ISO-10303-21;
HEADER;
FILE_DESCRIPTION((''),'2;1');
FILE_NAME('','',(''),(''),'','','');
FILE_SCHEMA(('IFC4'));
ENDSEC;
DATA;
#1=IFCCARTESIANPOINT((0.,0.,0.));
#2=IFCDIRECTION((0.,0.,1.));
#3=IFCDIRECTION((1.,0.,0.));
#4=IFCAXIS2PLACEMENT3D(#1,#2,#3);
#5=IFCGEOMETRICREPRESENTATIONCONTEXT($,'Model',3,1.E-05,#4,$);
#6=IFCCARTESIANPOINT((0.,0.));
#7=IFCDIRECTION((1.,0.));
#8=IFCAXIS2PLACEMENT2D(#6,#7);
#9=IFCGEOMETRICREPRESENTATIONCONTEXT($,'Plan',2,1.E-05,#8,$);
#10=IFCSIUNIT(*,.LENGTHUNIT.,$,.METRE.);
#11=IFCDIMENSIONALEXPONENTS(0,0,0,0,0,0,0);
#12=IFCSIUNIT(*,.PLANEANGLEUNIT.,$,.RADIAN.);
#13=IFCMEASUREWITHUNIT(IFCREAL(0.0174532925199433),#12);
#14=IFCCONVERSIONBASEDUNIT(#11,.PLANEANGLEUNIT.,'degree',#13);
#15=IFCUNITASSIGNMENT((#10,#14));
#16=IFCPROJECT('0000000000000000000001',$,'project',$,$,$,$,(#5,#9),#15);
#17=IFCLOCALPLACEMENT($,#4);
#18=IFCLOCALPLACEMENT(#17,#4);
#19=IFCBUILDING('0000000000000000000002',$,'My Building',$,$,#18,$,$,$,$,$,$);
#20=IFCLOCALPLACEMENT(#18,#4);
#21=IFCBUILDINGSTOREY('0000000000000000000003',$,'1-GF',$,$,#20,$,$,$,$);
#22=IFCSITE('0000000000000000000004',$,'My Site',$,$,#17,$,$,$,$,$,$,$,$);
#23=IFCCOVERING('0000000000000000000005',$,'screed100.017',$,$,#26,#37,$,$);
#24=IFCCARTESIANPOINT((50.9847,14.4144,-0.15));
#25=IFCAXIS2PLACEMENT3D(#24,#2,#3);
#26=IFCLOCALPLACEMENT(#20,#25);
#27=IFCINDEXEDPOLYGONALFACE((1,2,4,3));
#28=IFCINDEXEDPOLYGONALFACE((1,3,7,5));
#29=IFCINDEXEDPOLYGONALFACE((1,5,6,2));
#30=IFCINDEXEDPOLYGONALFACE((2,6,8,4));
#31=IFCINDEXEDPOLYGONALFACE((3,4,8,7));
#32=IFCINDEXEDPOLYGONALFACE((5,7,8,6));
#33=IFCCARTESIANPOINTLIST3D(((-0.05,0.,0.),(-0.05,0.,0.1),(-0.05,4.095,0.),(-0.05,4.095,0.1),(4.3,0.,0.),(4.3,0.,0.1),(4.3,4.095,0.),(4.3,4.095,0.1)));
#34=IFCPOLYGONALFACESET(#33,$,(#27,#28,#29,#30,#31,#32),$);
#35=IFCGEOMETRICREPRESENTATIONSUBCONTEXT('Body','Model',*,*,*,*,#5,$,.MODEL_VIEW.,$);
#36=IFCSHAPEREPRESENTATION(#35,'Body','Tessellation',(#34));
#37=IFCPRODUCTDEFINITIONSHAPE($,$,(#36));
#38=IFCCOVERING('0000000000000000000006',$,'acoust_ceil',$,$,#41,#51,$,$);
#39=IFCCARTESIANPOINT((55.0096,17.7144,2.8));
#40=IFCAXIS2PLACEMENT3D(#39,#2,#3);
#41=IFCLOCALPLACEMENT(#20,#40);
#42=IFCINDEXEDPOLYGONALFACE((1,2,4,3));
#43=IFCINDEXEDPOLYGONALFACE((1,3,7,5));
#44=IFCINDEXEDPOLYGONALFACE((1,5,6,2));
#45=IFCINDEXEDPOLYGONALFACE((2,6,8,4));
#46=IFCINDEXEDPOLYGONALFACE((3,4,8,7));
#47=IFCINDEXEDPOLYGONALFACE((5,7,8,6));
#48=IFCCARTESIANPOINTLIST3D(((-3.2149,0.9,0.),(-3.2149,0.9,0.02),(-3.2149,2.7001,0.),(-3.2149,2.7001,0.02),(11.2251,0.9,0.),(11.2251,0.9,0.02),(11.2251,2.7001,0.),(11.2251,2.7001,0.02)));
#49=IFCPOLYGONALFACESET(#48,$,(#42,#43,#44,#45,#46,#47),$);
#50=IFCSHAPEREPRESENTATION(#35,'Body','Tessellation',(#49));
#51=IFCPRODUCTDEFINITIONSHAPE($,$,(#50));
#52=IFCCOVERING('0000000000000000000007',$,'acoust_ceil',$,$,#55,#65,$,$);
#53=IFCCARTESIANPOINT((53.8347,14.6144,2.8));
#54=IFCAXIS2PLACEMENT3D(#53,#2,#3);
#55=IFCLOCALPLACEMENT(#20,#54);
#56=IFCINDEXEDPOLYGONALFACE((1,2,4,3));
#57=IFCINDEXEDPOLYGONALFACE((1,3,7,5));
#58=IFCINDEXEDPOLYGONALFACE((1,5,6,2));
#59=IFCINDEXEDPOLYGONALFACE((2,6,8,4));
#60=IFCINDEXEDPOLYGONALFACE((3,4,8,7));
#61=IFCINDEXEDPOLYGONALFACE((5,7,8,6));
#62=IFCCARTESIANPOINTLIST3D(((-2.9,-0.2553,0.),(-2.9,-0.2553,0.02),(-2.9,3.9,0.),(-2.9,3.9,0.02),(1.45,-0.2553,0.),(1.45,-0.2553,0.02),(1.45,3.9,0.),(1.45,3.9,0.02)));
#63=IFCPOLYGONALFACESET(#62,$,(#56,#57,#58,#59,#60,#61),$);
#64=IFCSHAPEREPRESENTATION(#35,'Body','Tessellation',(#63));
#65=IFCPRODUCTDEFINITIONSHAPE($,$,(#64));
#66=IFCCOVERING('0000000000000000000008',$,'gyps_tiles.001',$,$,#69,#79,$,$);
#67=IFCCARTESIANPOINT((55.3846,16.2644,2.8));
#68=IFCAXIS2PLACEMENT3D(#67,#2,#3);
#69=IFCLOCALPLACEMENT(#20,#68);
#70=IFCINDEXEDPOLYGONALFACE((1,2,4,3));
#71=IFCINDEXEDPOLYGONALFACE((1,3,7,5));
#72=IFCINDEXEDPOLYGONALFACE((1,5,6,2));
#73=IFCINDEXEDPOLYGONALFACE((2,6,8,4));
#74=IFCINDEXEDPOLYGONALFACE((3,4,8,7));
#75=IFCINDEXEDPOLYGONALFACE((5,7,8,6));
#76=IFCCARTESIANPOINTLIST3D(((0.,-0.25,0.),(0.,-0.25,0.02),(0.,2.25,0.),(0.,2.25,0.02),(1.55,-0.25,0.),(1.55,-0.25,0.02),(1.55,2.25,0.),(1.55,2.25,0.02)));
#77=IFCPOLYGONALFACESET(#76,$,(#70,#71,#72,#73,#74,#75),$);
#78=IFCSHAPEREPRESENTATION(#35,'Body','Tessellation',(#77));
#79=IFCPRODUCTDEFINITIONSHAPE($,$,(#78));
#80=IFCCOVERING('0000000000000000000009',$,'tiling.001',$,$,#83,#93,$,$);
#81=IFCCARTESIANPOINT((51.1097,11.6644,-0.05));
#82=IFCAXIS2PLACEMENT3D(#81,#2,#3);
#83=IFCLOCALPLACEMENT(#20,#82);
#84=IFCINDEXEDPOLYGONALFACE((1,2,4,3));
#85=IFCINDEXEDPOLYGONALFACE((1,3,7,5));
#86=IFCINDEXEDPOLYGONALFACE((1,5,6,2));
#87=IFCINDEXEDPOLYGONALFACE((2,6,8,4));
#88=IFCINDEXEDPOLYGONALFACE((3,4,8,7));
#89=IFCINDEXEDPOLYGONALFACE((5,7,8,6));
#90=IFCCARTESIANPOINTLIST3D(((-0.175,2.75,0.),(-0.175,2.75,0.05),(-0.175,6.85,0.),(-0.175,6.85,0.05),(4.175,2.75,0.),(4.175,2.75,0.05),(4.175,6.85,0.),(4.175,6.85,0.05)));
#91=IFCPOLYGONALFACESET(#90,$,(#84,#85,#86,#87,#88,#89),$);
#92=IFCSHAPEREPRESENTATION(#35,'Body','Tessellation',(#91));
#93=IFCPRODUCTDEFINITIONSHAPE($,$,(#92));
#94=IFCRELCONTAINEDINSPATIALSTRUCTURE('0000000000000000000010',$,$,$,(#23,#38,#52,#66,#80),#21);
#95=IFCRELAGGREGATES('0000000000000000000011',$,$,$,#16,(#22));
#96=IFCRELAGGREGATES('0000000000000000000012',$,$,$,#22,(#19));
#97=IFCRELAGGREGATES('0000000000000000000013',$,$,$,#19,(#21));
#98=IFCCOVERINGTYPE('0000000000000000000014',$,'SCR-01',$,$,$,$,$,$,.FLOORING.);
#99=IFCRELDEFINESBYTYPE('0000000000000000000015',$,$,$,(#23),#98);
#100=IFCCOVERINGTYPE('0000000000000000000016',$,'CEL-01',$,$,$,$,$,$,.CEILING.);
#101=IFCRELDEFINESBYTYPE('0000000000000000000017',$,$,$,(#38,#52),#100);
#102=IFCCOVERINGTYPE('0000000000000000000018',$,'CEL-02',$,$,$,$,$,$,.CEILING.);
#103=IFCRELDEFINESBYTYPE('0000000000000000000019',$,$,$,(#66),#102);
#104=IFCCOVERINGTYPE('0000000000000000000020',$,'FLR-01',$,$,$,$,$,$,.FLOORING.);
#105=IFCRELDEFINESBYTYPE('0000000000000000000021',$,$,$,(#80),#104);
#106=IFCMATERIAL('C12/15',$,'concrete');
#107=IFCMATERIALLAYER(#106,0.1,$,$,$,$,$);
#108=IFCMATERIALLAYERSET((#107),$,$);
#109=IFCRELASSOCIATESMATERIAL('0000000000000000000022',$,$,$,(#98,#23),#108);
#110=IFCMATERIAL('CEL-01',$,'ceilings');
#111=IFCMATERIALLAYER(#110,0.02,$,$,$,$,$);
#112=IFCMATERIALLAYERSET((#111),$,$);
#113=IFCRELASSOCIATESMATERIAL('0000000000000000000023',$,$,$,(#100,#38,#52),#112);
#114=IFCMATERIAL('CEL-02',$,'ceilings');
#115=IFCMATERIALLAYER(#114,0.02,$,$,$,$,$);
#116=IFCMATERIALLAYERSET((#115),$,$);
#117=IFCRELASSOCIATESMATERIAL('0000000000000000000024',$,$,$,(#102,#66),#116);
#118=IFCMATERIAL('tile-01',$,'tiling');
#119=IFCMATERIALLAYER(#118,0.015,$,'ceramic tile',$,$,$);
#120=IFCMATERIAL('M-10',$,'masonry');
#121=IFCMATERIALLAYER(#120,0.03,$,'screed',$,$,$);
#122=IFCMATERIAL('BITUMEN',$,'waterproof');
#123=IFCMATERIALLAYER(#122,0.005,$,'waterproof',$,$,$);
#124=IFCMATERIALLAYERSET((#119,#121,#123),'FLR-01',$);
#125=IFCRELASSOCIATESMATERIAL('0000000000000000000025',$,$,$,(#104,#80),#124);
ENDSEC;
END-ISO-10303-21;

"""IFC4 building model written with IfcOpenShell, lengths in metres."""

from ifc_helpers import new_model, entity, si_unit, converted_unit, frame, origin_with_axes, origin_2d_with_axis, place, context, subcontext, project, spatial, line, indexed_curve, outline, extrude, material, layer, layer_set, layer_usage, type_object, element, save


model = new_model("IFC4")

# Units and contexts
model_context = context("Model", 3, precision=1e-05, world=origin_with_axes())
plan_context = context("Plan", 2, precision=1e-05, world=origin_2d_with_axis())
body_context_1 = subcontext(model_context, "Body", "Model", "MODEL_VIEW")
ifc_project = project(units=[si_unit("LENGTHUNIT", "METRE"), converted_unit("PLANEANGLEUNIT", "degree", entity("IfcReal", 0.0174532925199433), si_unit("PLANEANGLEUNIT", "RADIAN"), dimensions=[0, 0, 0, 0, 0, 0, 0])], contexts=[model_context, plan_context])

# Site, building, storey
site_placement = place(None, origin_with_axes())
site = spatial("IfcSite", under=ifc_project, at=site_placement, Name="My Site")
building_placement = place(site_placement, origin_with_axes())
building = spatial("IfcBuilding", under=site, at=building_placement, Name="My Building")
storey_placement = place(building_placement, origin_with_axes())
storey = spatial("IfcBuildingStorey", under=building, at=storey_placement, Name="1-GF")

# Coverings
ifc_material_1 = material(Name="C12/15", Category="concrete")
ifc_layer_1 = layer(ifc_material_1, 0.1)
ifc_layer_set_1 = layer_set([ifc_layer_1])
ifc_layer_usage_1 = layer_usage(ifc_layer_set_1, "AXIS3", "POSITIVE", 0.0)
covering_type_1 = type_object("IfcCoveringType", Name="SCR-01", PredefinedType="FLOORING", material=ifc_layer_set_1)
covering_1_placement = place(storey_placement, frame((50.9847, 14.4144, -0.15), z_axis=(0.0, 0.0, 1.0), x_axis=(1.0, 0.0, 0.0)))
element("IfcCovering", 1, at=covering_1_placement, inside=storey, type_object=covering_type_1, material=ifc_layer_usage_1, Name="screed100.017", context=body_context_1, shape_type="SweptSolid", body=[
    extrude(outline(indexed_curve([(-0.05, 0.0), (4.3, 0.0), (4.3, 4.095), (-0.05, 4.095)], segments=[line(3, 2), line(2, 1), line(1, 4), line(4, 3)], self_intersect=False)), None, (0.0, 0.0, 1.0), 0.1),
])
ifc_material_2 = material(Name="CEL-01", Category="ceilings")
ifc_layer_2 = layer(ifc_material_2, 0.02)
ifc_layer_set_2 = layer_set([ifc_layer_2])
ifc_layer_usage_2 = layer_usage(ifc_layer_set_2, "AXIS3", "POSITIVE", 0.0)
covering_type_2 = type_object("IfcCoveringType", Name="CEL-01", PredefinedType="CEILING", material=ifc_layer_set_2)
covering_2_placement = place(storey_placement, frame((55.0096, 17.7144, 2.8), z_axis=(0.0, 0.0, 1.0), x_axis=(1.0, 0.0, 0.0)))
element("IfcCovering", 2, at=covering_2_placement, inside=storey, type_object=covering_type_2, material=ifc_layer_usage_2, Name="acoust_ceil", context=body_context_1, shape_type="SweptSolid", body=[
    extrude(outline(indexed_curve([(-3.2149, 0.9), (11.2251, 0.9), (11.2251, 2.7001), (-3.2149, 2.7001)], segments=[line(3, 2), line(2, 1), line(1, 4), line(4, 3)], self_intersect=False)), None, (0.0, 0.0, 1.0), 0.02),
])
ifc_layer_usage_3 = layer_usage(ifc_layer_set_2, "AXIS3", "POSITIVE", 0.0)
covering_3_placement = place(storey_placement, frame((53.8347, 14.6144, 2.8), z_axis=(0.0, 0.0, 1.0), x_axis=(1.0, 0.0, 0.0)))
element("IfcCovering", 3, at=covering_3_placement, inside=storey, type_object=covering_type_2, material=ifc_layer_usage_3, Name="acoust_ceil", context=body_context_1, shape_type="SweptSolid", body=[
    extrude(outline(indexed_curve([(-2.9, -0.2553), (1.45, -0.2553), (1.45, 3.9), (-2.9, 3.9)], segments=[line(4, 1), line(1, 2), line(2, 3), line(3, 4)], self_intersect=False)), None, (0.0, 0.0, 1.0), 0.02),
])
ifc_material_3 = material(Name="CEL-02", Category="ceilings")
ifc_layer_3 = layer(ifc_material_3, 0.02)
ifc_layer_set_3 = layer_set([ifc_layer_3])
ifc_layer_usage_4 = layer_usage(ifc_layer_set_3, "AXIS3", "POSITIVE", 0.0)
covering_type_3 = type_object("IfcCoveringType", Name="CEL-02", PredefinedType="CEILING", material=ifc_layer_set_3)
covering_4_placement = place(storey_placement, frame((55.3846, 16.2644, 2.8), z_axis=(0.0, 0.0, 1.0), x_axis=(1.0, 0.0, 0.0)))
element("IfcCovering", 4, at=covering_4_placement, inside=storey, type_object=covering_type_3, material=ifc_layer_usage_4, Name="gyps_tiles.001", context=body_context_1, shape_type="SweptSolid", body=[
    extrude(outline(indexed_curve([(1.55, 2.25), (1.55, -0.25), (0.0, -0.25), (0.0, 2.25)], segments=[line(3, 2), line(2, 1), line(1, 4), line(4, 3)], self_intersect=False)), None, (0.0, 0.0, 1.0), 0.02),
])
ifc_material_4 = material(Name="tile-01", Category="tiling")
ifc_layer_4 = layer(ifc_material_4, 0.015, Name="ceramic tile")
ifc_material_5 = material(Name="M-10", Category="masonry")
ifc_layer_5 = layer(ifc_material_5, 0.03, Name="screed")
ifc_material_6 = material(Name="BITUMEN", Category="waterproof")
ifc_layer_6 = layer(ifc_material_6, 0.005, Name="waterproof")
ifc_layer_set_4 = layer_set([ifc_layer_4, ifc_layer_5, ifc_layer_6], Name="FLR-01")
ifc_layer_usage_5 = layer_usage(ifc_layer_set_4, "AXIS3", "POSITIVE", 0.0)
covering_type_4 = type_object("IfcCoveringType", Name="FLR-01", PredefinedType="FLOORING", material=ifc_layer_set_4)
covering_5_placement = place(storey_placement, frame((51.1097, 11.6644, -0.05), z_axis=(0.0, 0.0, 1.0), x_axis=(1.0, 0.0, 0.0)))
element("IfcCovering", 5, at=covering_5_placement, inside=storey, type_object=covering_type_4, material=ifc_layer_usage_5, Name="tiling.001", context=body_context_1, shape_type="SweptSolid", body=[
    extrude(outline(indexed_curve([(-0.175, 2.75), (-0.175, 6.85), (4.175, 6.85), (4.175, 2.75)], segments=[line(3, 2), line(2, 1), line(1, 4), line(4, 3)], self_intersect=False)), None, (0.0, 0.0, 1.0), 0.05),
])

save(model, "model.ifc")
